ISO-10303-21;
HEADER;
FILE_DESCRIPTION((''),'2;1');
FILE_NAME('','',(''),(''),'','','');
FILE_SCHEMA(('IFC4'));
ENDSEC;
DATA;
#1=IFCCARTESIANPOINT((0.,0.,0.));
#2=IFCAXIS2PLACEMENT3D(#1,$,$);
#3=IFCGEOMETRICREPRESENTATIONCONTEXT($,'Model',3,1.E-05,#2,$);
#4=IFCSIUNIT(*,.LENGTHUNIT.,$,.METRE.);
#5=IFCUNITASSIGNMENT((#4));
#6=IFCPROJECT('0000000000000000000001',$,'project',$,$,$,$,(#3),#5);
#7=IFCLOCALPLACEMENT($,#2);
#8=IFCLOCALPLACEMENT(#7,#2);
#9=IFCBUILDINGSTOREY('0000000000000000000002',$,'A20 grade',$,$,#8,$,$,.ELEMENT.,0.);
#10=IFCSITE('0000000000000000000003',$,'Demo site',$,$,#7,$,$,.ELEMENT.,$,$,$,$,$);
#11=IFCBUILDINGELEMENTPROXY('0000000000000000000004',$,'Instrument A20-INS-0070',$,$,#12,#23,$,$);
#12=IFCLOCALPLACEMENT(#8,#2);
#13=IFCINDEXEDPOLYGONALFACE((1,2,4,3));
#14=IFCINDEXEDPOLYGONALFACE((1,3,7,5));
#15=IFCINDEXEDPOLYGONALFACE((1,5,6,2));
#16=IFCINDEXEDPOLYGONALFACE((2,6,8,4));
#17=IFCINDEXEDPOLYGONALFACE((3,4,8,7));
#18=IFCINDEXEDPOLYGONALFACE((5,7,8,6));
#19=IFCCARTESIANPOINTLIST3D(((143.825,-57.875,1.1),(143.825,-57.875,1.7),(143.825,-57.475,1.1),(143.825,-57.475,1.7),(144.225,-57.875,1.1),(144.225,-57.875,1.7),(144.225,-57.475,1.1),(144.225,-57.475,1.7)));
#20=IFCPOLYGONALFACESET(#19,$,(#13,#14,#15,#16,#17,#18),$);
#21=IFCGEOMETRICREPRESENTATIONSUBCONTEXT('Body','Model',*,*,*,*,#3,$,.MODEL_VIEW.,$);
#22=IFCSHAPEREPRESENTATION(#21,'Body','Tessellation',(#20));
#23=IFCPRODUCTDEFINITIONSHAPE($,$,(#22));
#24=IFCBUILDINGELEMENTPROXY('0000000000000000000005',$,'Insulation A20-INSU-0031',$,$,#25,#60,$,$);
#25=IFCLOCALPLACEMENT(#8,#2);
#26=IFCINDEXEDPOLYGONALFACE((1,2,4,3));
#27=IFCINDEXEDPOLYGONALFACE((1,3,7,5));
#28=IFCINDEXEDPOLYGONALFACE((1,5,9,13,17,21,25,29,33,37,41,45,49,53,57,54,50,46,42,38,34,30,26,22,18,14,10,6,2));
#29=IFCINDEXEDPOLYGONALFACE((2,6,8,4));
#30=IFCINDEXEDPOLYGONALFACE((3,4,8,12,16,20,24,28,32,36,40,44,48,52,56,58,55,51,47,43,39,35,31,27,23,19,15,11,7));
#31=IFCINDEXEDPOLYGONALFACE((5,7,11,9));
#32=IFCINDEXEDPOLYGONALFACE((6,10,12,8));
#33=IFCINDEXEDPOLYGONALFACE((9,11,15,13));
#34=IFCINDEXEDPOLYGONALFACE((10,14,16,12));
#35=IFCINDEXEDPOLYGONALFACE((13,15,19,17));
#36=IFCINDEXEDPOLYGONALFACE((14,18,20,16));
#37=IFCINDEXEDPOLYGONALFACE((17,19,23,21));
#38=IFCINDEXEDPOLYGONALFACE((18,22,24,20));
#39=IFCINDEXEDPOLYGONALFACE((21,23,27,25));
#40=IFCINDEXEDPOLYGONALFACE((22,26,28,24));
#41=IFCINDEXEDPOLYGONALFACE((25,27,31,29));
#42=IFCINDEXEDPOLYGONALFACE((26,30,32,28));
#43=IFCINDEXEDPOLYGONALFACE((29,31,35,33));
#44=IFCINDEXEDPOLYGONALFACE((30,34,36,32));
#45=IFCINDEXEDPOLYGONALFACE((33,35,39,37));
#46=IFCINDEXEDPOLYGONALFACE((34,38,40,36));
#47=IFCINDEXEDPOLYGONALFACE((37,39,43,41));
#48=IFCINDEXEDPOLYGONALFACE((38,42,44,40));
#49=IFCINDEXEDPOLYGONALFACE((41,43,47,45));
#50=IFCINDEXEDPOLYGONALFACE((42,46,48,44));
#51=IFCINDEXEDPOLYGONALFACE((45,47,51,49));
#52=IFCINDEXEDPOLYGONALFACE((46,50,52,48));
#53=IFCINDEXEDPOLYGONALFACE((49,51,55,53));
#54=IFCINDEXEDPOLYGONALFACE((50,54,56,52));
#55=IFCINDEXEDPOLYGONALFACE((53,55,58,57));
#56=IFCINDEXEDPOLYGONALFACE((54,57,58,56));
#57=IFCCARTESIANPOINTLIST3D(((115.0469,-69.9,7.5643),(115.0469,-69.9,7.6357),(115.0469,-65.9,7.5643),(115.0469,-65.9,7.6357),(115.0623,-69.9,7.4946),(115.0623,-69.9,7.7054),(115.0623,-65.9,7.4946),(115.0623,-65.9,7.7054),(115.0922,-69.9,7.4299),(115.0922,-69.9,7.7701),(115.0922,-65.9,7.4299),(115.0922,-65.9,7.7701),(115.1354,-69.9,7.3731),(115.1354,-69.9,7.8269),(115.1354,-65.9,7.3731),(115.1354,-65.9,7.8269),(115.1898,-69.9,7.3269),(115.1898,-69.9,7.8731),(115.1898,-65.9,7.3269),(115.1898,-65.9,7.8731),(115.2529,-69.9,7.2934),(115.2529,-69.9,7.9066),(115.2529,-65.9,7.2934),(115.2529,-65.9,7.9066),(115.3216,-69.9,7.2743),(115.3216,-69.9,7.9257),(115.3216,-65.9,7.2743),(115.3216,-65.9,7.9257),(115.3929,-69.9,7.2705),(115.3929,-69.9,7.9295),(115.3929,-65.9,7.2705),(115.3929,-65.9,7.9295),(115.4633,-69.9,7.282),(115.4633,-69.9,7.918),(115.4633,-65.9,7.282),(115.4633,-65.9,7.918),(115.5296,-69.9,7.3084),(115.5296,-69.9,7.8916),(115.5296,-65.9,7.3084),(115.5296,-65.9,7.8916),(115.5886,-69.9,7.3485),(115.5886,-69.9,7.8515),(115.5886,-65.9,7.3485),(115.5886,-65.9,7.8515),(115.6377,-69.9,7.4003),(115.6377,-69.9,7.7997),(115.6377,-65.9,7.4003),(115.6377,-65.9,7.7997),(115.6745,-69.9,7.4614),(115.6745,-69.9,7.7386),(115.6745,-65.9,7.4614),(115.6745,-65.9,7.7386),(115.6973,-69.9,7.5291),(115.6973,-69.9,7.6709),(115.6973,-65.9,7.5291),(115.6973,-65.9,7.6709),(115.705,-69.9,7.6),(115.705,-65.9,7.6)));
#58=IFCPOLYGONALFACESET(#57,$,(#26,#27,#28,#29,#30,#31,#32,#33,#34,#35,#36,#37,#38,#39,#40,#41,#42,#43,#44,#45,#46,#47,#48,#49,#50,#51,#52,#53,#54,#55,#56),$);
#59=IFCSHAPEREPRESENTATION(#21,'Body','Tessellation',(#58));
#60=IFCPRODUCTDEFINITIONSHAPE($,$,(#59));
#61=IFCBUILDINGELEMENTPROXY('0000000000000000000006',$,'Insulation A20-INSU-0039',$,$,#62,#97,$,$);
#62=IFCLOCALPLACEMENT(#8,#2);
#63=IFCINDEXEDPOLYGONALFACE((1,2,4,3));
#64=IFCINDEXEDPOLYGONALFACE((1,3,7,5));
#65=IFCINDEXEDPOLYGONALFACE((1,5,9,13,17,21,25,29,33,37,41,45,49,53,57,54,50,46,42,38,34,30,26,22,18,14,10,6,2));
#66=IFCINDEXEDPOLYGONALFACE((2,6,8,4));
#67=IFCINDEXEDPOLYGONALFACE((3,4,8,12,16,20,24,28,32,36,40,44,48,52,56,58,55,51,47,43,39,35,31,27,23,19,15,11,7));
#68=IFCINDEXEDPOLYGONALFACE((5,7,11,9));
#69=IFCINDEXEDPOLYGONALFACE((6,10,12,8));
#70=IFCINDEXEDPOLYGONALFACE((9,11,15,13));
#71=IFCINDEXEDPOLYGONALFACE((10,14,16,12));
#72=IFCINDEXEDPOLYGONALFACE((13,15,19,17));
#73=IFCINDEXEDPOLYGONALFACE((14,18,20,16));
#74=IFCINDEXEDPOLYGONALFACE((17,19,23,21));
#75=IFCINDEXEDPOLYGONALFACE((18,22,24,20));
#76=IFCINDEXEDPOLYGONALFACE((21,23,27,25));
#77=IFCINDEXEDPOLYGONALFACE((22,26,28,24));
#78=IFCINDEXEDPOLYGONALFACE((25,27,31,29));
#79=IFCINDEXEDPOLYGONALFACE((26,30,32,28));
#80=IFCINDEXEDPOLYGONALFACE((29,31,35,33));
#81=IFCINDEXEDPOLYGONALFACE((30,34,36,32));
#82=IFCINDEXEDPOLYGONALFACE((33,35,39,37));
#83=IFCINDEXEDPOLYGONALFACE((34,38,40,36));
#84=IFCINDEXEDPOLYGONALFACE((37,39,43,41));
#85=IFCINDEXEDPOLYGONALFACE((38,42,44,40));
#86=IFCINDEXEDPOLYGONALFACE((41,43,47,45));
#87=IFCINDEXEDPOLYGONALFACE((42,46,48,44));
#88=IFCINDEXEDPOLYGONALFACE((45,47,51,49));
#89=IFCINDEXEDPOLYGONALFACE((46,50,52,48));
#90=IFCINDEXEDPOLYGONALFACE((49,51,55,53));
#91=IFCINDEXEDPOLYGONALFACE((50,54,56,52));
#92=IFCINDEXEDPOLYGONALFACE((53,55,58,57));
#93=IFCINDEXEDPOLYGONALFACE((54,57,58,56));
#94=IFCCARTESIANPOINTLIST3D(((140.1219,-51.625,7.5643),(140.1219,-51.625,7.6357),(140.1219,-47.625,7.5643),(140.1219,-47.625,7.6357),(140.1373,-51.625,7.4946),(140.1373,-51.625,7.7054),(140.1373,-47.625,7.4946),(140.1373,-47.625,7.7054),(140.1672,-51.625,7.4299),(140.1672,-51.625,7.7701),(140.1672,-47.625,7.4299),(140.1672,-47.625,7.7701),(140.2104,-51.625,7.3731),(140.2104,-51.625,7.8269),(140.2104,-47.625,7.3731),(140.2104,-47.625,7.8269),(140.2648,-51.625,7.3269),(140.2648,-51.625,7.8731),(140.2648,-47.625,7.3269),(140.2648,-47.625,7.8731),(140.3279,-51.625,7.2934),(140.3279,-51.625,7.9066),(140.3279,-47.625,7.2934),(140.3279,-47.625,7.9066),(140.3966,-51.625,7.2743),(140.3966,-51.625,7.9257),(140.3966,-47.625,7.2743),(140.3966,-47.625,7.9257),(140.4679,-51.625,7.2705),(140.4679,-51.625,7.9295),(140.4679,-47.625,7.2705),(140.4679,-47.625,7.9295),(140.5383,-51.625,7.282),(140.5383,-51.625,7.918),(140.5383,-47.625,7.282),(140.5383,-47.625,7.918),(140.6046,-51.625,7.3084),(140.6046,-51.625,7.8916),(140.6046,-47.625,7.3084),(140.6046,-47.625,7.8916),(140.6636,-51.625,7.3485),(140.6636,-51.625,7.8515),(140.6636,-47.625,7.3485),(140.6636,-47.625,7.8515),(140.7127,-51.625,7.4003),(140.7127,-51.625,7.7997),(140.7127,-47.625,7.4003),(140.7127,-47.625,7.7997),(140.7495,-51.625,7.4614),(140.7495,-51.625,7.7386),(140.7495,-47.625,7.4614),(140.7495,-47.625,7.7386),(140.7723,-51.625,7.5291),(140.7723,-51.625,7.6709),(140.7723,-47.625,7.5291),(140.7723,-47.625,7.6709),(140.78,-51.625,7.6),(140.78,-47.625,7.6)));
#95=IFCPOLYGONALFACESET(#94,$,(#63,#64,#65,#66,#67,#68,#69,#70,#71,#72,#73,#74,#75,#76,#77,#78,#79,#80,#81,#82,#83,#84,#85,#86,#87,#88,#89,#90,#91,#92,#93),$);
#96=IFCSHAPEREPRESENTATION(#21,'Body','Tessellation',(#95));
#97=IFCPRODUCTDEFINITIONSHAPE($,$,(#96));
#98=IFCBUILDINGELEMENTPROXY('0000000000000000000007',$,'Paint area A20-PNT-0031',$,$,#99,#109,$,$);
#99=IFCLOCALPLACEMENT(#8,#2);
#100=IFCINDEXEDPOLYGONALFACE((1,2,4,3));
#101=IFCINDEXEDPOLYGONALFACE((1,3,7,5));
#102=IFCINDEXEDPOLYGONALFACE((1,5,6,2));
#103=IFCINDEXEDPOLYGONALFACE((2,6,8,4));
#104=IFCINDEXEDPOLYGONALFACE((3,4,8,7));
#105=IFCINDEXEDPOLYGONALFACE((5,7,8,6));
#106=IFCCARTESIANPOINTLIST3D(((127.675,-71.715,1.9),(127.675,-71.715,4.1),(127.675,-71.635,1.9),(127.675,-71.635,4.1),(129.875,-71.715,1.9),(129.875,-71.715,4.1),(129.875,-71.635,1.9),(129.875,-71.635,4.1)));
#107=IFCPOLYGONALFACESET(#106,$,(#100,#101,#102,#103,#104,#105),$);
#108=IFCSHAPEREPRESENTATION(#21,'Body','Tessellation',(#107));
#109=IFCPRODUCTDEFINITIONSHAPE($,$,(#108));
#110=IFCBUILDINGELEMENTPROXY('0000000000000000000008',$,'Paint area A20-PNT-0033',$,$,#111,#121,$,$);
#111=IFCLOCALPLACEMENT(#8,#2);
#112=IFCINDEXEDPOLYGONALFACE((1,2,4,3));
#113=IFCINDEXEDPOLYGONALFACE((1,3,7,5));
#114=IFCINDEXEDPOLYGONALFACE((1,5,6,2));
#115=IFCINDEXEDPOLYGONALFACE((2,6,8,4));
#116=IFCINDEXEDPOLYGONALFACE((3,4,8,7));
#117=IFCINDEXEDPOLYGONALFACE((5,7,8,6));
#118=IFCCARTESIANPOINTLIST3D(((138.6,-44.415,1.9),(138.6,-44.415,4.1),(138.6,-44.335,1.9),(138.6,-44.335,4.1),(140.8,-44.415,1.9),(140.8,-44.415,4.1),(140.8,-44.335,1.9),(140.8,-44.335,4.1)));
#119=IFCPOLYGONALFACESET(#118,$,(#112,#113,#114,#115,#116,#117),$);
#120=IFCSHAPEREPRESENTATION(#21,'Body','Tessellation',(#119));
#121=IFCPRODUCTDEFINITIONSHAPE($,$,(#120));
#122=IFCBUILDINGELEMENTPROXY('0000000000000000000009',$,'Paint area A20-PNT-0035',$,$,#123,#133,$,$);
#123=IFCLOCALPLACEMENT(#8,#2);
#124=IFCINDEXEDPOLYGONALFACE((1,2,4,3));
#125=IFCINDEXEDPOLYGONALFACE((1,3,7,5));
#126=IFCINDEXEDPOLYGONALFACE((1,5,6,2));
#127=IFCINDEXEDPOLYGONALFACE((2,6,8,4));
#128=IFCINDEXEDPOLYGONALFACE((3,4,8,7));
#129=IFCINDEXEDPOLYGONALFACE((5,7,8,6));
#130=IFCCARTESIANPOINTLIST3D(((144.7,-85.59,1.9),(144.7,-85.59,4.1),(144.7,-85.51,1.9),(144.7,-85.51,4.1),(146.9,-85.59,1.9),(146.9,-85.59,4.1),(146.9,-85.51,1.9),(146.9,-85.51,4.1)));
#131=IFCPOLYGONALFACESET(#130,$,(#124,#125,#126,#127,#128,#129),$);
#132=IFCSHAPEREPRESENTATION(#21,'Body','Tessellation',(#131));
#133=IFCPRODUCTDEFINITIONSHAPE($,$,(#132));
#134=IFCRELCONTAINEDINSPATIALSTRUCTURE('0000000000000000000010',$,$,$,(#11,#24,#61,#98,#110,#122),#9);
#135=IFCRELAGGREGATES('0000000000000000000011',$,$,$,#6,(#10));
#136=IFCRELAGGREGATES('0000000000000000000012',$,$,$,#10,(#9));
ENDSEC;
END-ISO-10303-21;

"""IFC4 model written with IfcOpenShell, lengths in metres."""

from ifc_helpers import new_model, si_unit, frame, origin, place, context, subcontext, project, spatial, rectangle, circle, extrude, element, save


model = new_model("IFC4")

# Units and contexts
model_context = context("Model", 3, precision=1e-05, world=origin())
body_context = subcontext(model_context, "Body", "Model", "MODEL_VIEW")
ifc_project = project(units=[si_unit("LENGTHUNIT", "METRE")], contexts=[model_context])

# Site, storey
site_placement = place(None, origin())
site = spatial("IfcSite", under=ifc_project, at=site_placement, Name="Demo site", CompositionType="ELEMENT")
storey_placement = place(site_placement, origin())
storey = spatial("IfcBuildingStorey", under=site, at=storey_placement, Name="A20 grade", CompositionType="ELEMENT", Elevation=0.0)

# Building element proxies
proxy_placement = place(storey_placement, frame((144.025, -57.675, 1.1)))
element("IfcBuildingElementProxy", 1, at=proxy_placement, inside=storey, Name="Instrument A20-INS-0070", context=body_context, shape_type="SweptSolid", body=[
    extrude(rectangle(XDim=0.4, YDim=0.4), origin(), (0.0, 0.0, 1.0), 0.6),
])
for number, where, name in (
    (2, (115.375, -69.9, 7.6), "Insulation A20-INSU-0031"),
    (3, (140.45, -51.625, 7.6), "Insulation A20-INSU-0039"),
):
    element("IfcBuildingElementProxy", number, at=place(storey_placement, frame(where)), inside=storey, Name=name, context=body_context, shape_type="SweptSolid", body=[
        extrude(circle(Radius=0.33), frame((0.0, 0.0, 0.0), z_axis=(0.0, 1.0, 0.0), x_axis=(1.0, 0.0, 0.0)), (0.0, 0.0, 1.0), 4.0),
    ])
for number, where, name in (
    (4, (128.775, -71.675, 1.9), "Paint area A20-PNT-0031"),
    (5, (139.7, -44.375, 1.9), "Paint area A20-PNT-0033"),
    (6, (145.8, -85.55, 1.9), "Paint area A20-PNT-0035"),
):
    element("IfcBuildingElementProxy", number, at=place(storey_placement, frame(where)), inside=storey, Name=name, context=body_context, shape_type="SweptSolid", body=[
        extrude(rectangle(XDim=2.2, YDim=0.08), origin(), (0.0, 0.0, 1.0), 2.2),
    ])

save(model, "model.ifc")
